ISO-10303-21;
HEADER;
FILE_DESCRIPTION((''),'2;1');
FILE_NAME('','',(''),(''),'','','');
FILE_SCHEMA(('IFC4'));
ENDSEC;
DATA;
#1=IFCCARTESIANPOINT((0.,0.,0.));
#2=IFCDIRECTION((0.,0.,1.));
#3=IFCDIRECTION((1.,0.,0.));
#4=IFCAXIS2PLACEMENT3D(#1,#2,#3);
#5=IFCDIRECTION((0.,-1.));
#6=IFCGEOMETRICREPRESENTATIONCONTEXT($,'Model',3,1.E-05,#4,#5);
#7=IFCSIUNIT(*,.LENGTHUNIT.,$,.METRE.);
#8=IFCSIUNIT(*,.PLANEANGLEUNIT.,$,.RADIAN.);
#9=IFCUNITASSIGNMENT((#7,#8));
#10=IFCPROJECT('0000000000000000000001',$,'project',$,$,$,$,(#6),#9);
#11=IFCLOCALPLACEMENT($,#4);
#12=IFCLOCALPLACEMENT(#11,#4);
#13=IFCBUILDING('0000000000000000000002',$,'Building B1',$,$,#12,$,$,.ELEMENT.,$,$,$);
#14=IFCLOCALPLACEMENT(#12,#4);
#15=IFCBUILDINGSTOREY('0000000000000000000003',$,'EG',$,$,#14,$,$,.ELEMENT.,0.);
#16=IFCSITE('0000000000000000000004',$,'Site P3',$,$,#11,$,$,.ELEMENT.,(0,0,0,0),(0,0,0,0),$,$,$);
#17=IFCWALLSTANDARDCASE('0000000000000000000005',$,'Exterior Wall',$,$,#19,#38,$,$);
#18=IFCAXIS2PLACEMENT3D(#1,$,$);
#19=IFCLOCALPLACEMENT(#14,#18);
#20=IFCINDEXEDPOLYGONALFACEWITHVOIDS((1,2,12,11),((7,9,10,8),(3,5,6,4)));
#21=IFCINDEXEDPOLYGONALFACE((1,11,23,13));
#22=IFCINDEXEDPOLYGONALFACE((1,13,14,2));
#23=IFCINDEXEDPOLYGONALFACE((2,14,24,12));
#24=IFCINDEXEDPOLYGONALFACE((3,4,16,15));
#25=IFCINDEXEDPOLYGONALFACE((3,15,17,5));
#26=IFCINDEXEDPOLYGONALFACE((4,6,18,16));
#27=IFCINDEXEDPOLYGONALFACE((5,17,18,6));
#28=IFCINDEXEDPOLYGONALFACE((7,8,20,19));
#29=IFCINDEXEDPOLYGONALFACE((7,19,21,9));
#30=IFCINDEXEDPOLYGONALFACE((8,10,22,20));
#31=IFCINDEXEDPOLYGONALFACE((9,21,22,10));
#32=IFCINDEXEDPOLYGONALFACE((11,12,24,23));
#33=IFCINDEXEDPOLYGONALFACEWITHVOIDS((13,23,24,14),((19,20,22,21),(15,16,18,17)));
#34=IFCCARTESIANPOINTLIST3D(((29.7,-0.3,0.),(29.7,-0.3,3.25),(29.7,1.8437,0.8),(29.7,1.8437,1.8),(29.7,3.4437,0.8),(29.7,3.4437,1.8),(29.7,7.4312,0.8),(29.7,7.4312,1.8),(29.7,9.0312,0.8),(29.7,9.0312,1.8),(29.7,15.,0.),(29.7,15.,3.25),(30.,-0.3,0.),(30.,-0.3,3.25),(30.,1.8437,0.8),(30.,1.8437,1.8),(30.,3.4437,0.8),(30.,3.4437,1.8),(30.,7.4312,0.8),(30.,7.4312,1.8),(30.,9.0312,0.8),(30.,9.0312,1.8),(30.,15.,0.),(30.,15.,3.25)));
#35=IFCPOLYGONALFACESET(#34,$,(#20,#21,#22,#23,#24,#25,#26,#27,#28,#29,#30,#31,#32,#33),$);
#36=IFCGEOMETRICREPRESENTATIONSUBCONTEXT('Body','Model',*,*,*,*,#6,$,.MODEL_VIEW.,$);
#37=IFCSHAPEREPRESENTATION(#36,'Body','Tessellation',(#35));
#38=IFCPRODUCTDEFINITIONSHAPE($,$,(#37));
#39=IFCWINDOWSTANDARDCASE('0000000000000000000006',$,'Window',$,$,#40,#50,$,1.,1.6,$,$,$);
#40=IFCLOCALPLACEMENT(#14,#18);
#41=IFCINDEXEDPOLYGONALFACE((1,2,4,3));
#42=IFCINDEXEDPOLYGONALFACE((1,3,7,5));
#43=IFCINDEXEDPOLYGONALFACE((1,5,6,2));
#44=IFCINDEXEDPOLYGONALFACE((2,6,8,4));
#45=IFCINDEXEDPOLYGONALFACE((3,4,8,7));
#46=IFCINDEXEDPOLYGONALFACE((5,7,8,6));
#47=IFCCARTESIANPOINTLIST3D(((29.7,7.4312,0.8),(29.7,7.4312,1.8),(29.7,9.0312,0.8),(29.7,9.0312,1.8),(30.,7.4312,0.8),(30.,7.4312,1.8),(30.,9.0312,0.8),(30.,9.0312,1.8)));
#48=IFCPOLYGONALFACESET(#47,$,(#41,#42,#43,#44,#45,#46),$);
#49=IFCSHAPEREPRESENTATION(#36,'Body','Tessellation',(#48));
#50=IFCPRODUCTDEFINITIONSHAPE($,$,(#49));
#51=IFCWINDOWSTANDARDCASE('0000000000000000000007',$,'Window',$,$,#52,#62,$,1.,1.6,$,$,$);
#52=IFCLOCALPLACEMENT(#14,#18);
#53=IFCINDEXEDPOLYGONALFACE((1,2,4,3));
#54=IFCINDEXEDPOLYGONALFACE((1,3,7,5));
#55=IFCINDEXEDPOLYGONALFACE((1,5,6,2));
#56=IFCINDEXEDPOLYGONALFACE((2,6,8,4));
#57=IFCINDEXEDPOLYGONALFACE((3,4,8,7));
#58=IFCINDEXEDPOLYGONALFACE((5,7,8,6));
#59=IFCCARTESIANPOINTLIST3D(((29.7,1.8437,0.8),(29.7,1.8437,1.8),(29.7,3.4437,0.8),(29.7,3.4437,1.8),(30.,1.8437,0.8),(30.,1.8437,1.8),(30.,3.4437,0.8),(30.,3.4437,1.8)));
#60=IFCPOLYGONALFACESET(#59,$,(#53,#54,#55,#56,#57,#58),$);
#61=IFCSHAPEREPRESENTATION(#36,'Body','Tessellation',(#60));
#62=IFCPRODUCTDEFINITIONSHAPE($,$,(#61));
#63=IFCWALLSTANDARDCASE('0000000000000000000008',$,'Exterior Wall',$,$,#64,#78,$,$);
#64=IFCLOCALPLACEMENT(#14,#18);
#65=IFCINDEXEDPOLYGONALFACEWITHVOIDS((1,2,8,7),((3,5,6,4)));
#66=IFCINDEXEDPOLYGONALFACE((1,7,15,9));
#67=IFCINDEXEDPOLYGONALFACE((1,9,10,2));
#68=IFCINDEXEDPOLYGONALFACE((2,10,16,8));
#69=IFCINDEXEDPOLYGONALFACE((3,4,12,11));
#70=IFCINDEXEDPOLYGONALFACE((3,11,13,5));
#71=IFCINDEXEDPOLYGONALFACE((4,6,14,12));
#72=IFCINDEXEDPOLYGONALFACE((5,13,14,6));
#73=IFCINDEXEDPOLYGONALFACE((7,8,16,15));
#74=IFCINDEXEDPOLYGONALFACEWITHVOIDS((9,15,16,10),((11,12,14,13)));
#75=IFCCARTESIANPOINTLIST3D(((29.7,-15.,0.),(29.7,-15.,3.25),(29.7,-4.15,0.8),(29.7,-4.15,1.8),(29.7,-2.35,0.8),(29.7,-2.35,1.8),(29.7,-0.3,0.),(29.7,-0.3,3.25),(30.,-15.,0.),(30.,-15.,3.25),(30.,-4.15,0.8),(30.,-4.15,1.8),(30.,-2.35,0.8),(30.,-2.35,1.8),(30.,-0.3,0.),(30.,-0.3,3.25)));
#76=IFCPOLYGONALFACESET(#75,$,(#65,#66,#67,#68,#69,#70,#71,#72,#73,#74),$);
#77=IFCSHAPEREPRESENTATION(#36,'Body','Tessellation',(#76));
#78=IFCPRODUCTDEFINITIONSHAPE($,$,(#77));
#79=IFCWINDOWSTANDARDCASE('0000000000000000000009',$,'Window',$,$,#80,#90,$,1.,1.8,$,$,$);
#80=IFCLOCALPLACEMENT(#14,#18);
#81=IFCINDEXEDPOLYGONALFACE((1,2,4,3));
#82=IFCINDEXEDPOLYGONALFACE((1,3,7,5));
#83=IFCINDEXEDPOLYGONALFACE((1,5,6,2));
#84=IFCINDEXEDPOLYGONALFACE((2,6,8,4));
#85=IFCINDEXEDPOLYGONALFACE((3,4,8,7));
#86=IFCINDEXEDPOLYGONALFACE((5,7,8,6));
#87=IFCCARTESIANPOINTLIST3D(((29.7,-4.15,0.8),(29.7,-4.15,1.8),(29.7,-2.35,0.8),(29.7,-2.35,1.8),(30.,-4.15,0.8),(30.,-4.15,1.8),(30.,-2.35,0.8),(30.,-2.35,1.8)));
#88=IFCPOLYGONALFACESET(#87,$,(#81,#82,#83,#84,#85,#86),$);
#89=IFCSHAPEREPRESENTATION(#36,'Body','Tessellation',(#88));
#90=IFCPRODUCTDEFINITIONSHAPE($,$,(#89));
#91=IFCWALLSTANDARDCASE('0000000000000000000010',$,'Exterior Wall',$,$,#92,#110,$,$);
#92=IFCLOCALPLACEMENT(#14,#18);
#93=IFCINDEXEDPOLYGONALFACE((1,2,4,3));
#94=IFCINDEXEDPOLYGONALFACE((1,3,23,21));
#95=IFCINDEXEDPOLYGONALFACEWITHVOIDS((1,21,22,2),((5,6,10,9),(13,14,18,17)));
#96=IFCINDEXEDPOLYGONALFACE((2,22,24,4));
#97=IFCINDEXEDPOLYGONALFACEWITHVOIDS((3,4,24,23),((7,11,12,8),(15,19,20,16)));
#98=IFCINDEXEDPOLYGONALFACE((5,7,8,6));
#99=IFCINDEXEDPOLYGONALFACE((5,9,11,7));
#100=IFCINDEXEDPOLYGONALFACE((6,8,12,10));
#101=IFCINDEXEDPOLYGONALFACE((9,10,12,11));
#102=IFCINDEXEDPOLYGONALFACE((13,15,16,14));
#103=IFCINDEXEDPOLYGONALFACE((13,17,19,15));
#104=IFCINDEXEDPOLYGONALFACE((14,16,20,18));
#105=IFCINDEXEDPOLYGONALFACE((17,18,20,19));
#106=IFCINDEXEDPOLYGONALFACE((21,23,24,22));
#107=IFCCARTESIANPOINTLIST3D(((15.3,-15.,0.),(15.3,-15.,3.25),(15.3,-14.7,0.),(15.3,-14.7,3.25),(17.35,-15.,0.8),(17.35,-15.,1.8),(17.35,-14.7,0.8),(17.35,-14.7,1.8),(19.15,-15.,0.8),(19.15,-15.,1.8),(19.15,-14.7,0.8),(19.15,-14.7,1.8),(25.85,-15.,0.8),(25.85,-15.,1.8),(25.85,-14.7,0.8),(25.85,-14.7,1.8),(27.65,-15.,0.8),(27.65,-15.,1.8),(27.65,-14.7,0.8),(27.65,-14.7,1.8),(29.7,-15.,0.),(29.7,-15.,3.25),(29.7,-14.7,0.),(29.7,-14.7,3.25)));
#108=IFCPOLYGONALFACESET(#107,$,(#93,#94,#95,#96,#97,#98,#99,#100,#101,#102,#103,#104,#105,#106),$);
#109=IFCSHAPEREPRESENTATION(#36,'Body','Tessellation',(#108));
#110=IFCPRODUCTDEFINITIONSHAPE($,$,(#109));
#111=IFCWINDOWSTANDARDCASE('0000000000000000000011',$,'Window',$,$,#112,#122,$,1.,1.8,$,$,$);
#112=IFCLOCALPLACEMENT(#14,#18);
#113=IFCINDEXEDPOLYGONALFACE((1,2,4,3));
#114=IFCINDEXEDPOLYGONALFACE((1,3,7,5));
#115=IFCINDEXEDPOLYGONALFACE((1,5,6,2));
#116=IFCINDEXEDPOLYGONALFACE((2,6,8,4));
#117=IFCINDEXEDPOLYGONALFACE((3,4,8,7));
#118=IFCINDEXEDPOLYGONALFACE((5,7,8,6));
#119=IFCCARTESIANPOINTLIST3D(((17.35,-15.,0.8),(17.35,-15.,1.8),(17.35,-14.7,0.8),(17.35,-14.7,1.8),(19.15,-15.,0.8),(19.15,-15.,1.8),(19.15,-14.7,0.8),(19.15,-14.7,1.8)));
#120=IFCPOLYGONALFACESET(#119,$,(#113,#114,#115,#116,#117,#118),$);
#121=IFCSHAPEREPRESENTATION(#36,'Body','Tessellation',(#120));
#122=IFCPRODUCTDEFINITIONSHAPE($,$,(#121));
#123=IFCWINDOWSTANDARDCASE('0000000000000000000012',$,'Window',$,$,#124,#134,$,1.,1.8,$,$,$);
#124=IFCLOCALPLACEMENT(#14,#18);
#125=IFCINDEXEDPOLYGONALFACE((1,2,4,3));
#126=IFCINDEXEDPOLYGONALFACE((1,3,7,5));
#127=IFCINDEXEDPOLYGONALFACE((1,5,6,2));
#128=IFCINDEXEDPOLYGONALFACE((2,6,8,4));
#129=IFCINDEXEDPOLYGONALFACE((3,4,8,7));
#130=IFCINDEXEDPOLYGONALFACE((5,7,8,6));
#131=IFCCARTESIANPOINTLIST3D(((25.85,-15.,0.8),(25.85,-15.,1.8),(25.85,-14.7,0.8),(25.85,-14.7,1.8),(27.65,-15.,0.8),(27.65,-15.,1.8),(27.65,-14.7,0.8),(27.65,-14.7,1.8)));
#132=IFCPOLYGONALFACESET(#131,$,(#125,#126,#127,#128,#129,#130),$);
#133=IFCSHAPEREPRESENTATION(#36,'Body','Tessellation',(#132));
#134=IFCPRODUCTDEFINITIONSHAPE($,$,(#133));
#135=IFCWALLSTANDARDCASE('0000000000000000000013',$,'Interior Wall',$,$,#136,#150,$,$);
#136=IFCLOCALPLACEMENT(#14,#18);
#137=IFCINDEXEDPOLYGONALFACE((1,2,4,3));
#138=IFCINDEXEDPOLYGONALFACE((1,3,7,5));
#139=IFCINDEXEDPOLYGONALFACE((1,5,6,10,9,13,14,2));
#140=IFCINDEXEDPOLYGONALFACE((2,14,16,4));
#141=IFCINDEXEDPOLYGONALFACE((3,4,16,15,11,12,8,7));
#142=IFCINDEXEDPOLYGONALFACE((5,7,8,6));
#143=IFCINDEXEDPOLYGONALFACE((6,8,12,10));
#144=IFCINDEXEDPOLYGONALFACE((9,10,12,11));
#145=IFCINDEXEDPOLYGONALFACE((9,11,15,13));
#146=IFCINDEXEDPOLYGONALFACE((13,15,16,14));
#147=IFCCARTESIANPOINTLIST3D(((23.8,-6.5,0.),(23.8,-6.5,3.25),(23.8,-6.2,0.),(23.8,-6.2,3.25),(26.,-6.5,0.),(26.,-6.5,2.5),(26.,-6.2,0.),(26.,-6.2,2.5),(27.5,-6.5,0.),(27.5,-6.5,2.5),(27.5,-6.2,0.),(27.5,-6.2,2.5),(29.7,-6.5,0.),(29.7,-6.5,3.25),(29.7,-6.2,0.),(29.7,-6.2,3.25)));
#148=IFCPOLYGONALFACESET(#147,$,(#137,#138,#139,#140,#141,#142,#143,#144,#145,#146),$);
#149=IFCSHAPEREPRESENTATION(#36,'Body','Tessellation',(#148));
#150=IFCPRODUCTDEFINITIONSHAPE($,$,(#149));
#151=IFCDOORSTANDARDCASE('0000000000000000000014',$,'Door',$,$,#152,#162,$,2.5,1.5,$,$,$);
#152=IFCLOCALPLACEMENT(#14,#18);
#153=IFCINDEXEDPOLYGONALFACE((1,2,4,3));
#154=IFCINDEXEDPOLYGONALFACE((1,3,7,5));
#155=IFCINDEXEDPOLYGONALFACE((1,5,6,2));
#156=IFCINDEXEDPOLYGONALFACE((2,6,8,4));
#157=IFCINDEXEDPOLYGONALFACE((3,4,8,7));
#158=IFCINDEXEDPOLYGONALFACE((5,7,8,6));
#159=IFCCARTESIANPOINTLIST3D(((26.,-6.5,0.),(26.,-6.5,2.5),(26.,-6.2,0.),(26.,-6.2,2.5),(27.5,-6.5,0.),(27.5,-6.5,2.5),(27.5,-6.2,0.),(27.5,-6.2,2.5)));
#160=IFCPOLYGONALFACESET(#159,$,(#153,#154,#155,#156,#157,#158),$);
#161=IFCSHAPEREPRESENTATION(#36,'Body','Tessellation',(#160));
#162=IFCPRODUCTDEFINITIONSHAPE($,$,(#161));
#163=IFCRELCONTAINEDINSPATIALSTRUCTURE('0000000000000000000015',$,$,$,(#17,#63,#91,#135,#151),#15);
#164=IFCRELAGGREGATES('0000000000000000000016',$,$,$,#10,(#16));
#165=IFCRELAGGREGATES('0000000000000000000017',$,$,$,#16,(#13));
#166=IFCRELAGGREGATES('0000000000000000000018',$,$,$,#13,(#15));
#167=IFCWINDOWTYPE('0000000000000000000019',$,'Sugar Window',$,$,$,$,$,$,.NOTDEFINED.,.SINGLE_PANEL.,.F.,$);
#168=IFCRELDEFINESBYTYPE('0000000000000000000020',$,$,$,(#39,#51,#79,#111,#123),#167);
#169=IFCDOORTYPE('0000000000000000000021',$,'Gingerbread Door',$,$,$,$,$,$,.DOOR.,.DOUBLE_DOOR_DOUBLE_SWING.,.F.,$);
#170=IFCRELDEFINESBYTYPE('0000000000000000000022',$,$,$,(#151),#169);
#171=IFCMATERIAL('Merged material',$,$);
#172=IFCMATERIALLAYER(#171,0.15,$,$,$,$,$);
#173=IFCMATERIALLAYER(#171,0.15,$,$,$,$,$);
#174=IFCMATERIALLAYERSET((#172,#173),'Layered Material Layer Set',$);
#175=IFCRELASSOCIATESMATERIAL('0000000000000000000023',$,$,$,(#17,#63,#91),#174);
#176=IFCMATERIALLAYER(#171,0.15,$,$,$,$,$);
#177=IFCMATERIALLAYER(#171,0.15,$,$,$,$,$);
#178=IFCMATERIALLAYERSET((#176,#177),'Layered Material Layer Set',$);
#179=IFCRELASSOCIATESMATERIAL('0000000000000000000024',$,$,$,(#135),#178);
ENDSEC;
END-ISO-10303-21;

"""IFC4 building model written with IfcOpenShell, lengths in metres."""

from ifc_helpers import new_model, si_unit, direction, frame, origin_with_axes, place, context, subcontext, project, spatial, polyline, outline, extrude, source, transform, mapped, material, layer, layer_set, layer_usage, type_object, element, fill, save


model = new_model("IFC4")

# Units and contexts
model_context = context("Model", 3, precision=1e-05, world=origin_with_axes(), true_north=direction((0.0, -1.0)))
body_context = subcontext(model_context, "Body", "Model", "MODEL_VIEW")
ifc_project = project(units=[si_unit("LENGTHUNIT", "METRE"), si_unit("PLANEANGLEUNIT", "RADIAN")], contexts=[model_context])

# Site, building, storey
site_placement = place(None, origin_with_axes())
site = spatial("IfcSite", under=ifc_project, at=site_placement, Name="Site P3", CompositionType="ELEMENT", RefLatitude=(0, 0, 0, 0), RefLongitude=(0, 0, 0, 0))
building_placement = place(site_placement, origin_with_axes())
building = spatial("IfcBuilding", under=site, at=building_placement, Name="Building B1", CompositionType="ELEMENT")
storey_placement = place(building_placement, origin_with_axes())
storey = spatial("IfcBuildingStorey", under=building, at=storey_placement, Name="EG", CompositionType="ELEMENT", Elevation=0.0)

# Wall, openings, windows
ifc_material = material(Name="Merged material")
ifc_layer_1 = layer(ifc_material, 0.15)
ifc_layer_2 = layer(ifc_material, 0.15)
ifc_layer_set_1 = layer_set([ifc_layer_1, ifc_layer_2], Name="Layered Material Layer Set")
ifc_layer_usage_1 = layer_usage(ifc_layer_set_1, "AXIS2", "POSITIVE", -0.15)
wall_1_placement = place(storey_placement, frame((29.85, -0.3, 0.0), z_axis=(0.0, 0.0, 1.0), x_axis=(0.0, 1.0, 0.0)))
wall_1 = element("IfcWallStandardCase", 1, at=wall_1_placement, inside=storey, material=ifc_layer_usage_1, Name="Exterior Wall", context=body_context, shape_type="SweptSolid", body=[
    extrude(outline(polyline([(0.0, 0.15), (15.3, 0.15), (15.3, -0.15), (0.0, -0.15), (0.0, 0.15)])), origin_with_axes(), (0.0, 0.0, 1.0), 3.25),
])
opening_1_placement = place(wall_1_placement, frame((7.7312, 0.0, 0.8), z_axis=(0.0, 0.0, 1.0), x_axis=(1.0, 0.0, 0.0)))
opening_1 = element("IfcOpeningStandardCase", 2, at=opening_1_placement, cuts=wall_1, context=body_context, shape_type="SweptSolid", body=[
    extrude(outline(polyline([(0.0, 0.0), (0.0, 1.6), (1.0, 1.6), (1.0, 0.0), (0.0, 0.0)])), frame((0.0, -0.15, 0.0), z_axis=(0.0, 1.0, 0.0), x_axis=(0.0, 0.0, 1.0)), (0.0, 0.0, 1.0), 0.3),
])
opening_2_placement = place(wall_1_placement, frame((2.1437, 0.0, 0.8), z_axis=(0.0, 0.0, 1.0), x_axis=(1.0, 0.0, 0.0)))
opening_2 = element("IfcOpeningStandardCase", 3, at=opening_2_placement, cuts=wall_1, context=body_context, shape_type="SweptSolid", body=[
    extrude(outline(polyline([(0.0, 0.0), (0.0, 1.6), (1.0, 1.6), (1.0, 0.0), (0.0, 0.0)])), frame((0.0, -0.15, 0.0), z_axis=(0.0, 1.0, 0.0), x_axis=(0.0, 0.0, 1.0)), (0.0, 0.0, 1.0), 0.3),
])
window_type = type_object("IfcWindowType", Name="Sugar Window", ParameterTakesPrecedence=False, PartitioningType="SINGLE_PANEL", PredefinedType="NOTDEFINED")
shared_shape_1 = source(origin_with_axes(), body_context, "Body", "SweptSolid", [
    extrude(outline(polyline([(0.0, 0.0), (0.0, 1.6), (1.0, 1.6), (1.0, 0.0), (0.0, 0.0)])), frame((0.0, -0.15, 0.0), z_axis=(0.0, 1.0, 0.0), x_axis=(0.0, 0.0, 1.0)), (0.0, 0.0, 1.0), 0.3),
])
window_1_placement = place(opening_1_placement, origin_with_axes())
window_1 = element("IfcWindowStandardCase", 4, at=window_1_placement, type_object=window_type, Name="Window", OverallHeight=1.0, OverallWidth=1.6, context=body_context, shape_type="MappedRepresentation", body=[
    mapped(shared_shape_1, transform((0.0, 0.0, 0.0))),
])
fill(opening_1, window_1)
window_2_placement = place(opening_2_placement, origin_with_axes())
window_2 = element("IfcWindowStandardCase", 5, at=window_2_placement, type_object=window_type, Name="Window", OverallHeight=1.0, OverallWidth=1.6, context=body_context, shape_type="MappedRepresentation", body=[
    mapped(shared_shape_1, transform((0.0, 0.0, 0.0))),
])
fill(opening_2, window_2)

# Wall, opening, window
wall_2_placement = place(storey_placement, frame((29.85, -15.0, 0.0), z_axis=(0.0, 0.0, 1.0), x_axis=(0.0, 1.0, 0.0)))
wall_2 = element("IfcWallStandardCase", 6, at=wall_2_placement, inside=storey, material=ifc_layer_usage_1, Name="Exterior Wall", context=body_context, shape_type="SweptSolid", body=[
    extrude(outline(polyline([(0.0, 0.15), (14.7, 0.15), (14.7, -0.15), (0.0, -0.15), (0.0, 0.15)])), origin_with_axes(), (0.0, 0.0, 1.0), 3.25),
])
opening_3_placement = place(wall_2_placement, frame((10.85, 0.0, 0.8), z_axis=(0.0, 0.0, 1.0), x_axis=(1.0, 0.0, 0.0)))
opening_3 = element("IfcOpeningStandardCase", 7, at=opening_3_placement, cuts=wall_2, context=body_context, shape_type="SweptSolid", body=[
    extrude(outline(polyline([(0.0, 0.0), (0.0, 1.8), (1.0, 1.8), (1.0, 0.0), (0.0, 0.0)])), frame((0.0, -0.15, 0.0), z_axis=(0.0, 1.0, 0.0), x_axis=(0.0, 0.0, 1.0)), (0.0, 0.0, 1.0), 0.3),
])
shared_shape_2 = source(origin_with_axes(), body_context, "Body", "SweptSolid", [
    extrude(outline(polyline([(0.0, 0.0), (0.0, 1.8), (1.0, 1.8), (1.0, 0.0), (0.0, 0.0)])), frame((0.0, -0.15, 0.0), z_axis=(0.0, 1.0, 0.0), x_axis=(0.0, 0.0, 1.0)), (0.0, 0.0, 1.0), 0.3),
])
window_3_placement = place(opening_3_placement, origin_with_axes())
window_3 = element("IfcWindowStandardCase", 8, at=window_3_placement, type_object=window_type, Name="Window", OverallHeight=1.0, OverallWidth=1.8, context=body_context, shape_type="MappedRepresentation", body=[
    mapped(shared_shape_2, transform((0.0, 0.0, 0.0))),
])
fill(opening_3, window_3)

# Wall, openings, windows
wall_3_placement = place(storey_placement, frame((15.3, -14.85, 0.0), z_axis=(0.0, 0.0, 1.0), x_axis=(1.0, 0.0, 0.0)))
wall_3 = element("IfcWallStandardCase", 9, at=wall_3_placement, inside=storey, material=ifc_layer_usage_1, Name="Exterior Wall", context=body_context, shape_type="SweptSolid", body=[
    extrude(outline(polyline([(0.0, 0.15), (14.4, 0.15), (14.4, -0.15), (0.0, -0.15), (0.0, 0.15)])), origin_with_axes(), (0.0, 0.0, 1.0), 3.25),
])
opening_4_placement = place(wall_3_placement, frame((2.05, 0.0, 0.8), z_axis=(0.0, 0.0, 1.0), x_axis=(1.0, 0.0, 0.0)))
opening_4 = element("IfcOpeningStandardCase", 10, at=opening_4_placement, cuts=wall_3, context=body_context, shape_type="SweptSolid", body=[
    extrude(outline(polyline([(0.0, 0.0), (0.0, 1.8), (1.0, 1.8), (1.0, 0.0), (0.0, 0.0)])), frame((0.0, -0.15, 0.0), z_axis=(0.0, 1.0, 0.0), x_axis=(0.0, 0.0, 1.0)), (0.0, 0.0, 1.0), 0.3),
])
opening_5_placement = place(wall_3_placement, frame((10.55, 0.0, 0.8), z_axis=(0.0, 0.0, 1.0), x_axis=(1.0, 0.0, 0.0)))
opening_5 = element("IfcOpeningStandardCase", 11, at=opening_5_placement, cuts=wall_3, context=body_context, shape_type="SweptSolid", body=[
    extrude(outline(polyline([(0.0, 0.0), (0.0, 1.8), (1.0, 1.8), (1.0, 0.0), (0.0, 0.0)])), frame((0.0, -0.15, 0.0), z_axis=(0.0, 1.0, 0.0), x_axis=(0.0, 0.0, 1.0)), (0.0, 0.0, 1.0), 0.3),
])
window_4_placement = place(opening_4_placement, origin_with_axes())
window_4 = element("IfcWindowStandardCase", 12, at=window_4_placement, type_object=window_type, Name="Window", OverallHeight=1.0, OverallWidth=1.8, context=body_context, shape_type="MappedRepresentation", body=[
    mapped(shared_shape_2, transform((0.0, 0.0, 0.0))),
])
fill(opening_4, window_4)
window_5_placement = place(opening_5_placement, origin_with_axes())
window_5 = element("IfcWindowStandardCase", 13, at=window_5_placement, type_object=window_type, Name="Window", OverallHeight=1.0, OverallWidth=1.8, context=body_context, shape_type="MappedRepresentation", body=[
    mapped(shared_shape_2, transform((0.0, 0.0, 0.0))),
])
fill(opening_5, window_5)

# Wall, opening, door
ifc_layer_3 = layer(ifc_material, 0.15)
ifc_layer_4 = layer(ifc_material, 0.15)
ifc_layer_set_2 = layer_set([ifc_layer_3, ifc_layer_4], Name="Layered Material Layer Set")
ifc_layer_usage_2 = layer_usage(ifc_layer_set_2, "AXIS2", "POSITIVE", -0.15)
wall_4_placement = place(storey_placement, frame((23.8, -6.35, 0.0), z_axis=(0.0, 0.0, 1.0), x_axis=(1.0, 0.0, 0.0)))
wall_4 = element("IfcWallStandardCase", 14, at=wall_4_placement, inside=storey, material=ifc_layer_usage_2, Name="Interior Wall", context=body_context, shape_type="SweptSolid", body=[
    extrude(outline(polyline([(0.0, 0.15), (5.9, 0.15), (5.9, -0.15), (0.0, -0.15), (0.0, 0.15)])), origin_with_axes(), (0.0, 0.0, 1.0), 3.25),
])
opening_6_placement = place(wall_4_placement, frame((2.2, 0.0, 0.0), z_axis=(0.0, 0.0, 1.0), x_axis=(1.0, 0.0, 0.0)))
opening_6 = element("IfcOpeningStandardCase", 15, at=opening_6_placement, cuts=wall_4, context=body_context, shape_type="SweptSolid", body=[
    extrude(outline(polyline([(0.0, 0.0), (0.0, 1.5), (2.5, 1.5), (2.5, 0.0), (0.0, 0.0)])), frame((0.0, -0.15, 0.0), z_axis=(0.0, 1.0, 0.0), x_axis=(0.0, 0.0, 1.0)), (0.0, 0.0, 1.0), 0.3),
])
door_type = type_object("IfcDoorType", Name="Gingerbread Door", OperationType="DOUBLE_DOOR_DOUBLE_SWING", ParameterTakesPrecedence=False, PredefinedType="DOOR")
shared_shape_3 = source(origin_with_axes(), body_context, "Body", "SweptSolid", [
    extrude(outline(polyline([(0.0, 0.0), (0.0, 1.5), (2.5, 1.5), (2.5, 0.0), (0.0, 0.0)])), frame((0.0, -0.15, 0.0), z_axis=(0.0, 1.0, 0.0), x_axis=(0.0, 0.0, 1.0)), (0.0, 0.0, 1.0), 0.3),
])
door_1_placement = place(opening_6_placement, origin_with_axes())
door_1 = element("IfcDoorStandardCase", 16, at=door_1_placement, inside=storey, type_object=door_type, Name="Door", OverallHeight=2.5, OverallWidth=1.5, context=body_context, shape_type="MappedRepresentation", body=[
    mapped(shared_shape_3, transform((0.0, 0.0, 0.0))),
])
fill(opening_6, door_1)

save(model, "model.ifc")
